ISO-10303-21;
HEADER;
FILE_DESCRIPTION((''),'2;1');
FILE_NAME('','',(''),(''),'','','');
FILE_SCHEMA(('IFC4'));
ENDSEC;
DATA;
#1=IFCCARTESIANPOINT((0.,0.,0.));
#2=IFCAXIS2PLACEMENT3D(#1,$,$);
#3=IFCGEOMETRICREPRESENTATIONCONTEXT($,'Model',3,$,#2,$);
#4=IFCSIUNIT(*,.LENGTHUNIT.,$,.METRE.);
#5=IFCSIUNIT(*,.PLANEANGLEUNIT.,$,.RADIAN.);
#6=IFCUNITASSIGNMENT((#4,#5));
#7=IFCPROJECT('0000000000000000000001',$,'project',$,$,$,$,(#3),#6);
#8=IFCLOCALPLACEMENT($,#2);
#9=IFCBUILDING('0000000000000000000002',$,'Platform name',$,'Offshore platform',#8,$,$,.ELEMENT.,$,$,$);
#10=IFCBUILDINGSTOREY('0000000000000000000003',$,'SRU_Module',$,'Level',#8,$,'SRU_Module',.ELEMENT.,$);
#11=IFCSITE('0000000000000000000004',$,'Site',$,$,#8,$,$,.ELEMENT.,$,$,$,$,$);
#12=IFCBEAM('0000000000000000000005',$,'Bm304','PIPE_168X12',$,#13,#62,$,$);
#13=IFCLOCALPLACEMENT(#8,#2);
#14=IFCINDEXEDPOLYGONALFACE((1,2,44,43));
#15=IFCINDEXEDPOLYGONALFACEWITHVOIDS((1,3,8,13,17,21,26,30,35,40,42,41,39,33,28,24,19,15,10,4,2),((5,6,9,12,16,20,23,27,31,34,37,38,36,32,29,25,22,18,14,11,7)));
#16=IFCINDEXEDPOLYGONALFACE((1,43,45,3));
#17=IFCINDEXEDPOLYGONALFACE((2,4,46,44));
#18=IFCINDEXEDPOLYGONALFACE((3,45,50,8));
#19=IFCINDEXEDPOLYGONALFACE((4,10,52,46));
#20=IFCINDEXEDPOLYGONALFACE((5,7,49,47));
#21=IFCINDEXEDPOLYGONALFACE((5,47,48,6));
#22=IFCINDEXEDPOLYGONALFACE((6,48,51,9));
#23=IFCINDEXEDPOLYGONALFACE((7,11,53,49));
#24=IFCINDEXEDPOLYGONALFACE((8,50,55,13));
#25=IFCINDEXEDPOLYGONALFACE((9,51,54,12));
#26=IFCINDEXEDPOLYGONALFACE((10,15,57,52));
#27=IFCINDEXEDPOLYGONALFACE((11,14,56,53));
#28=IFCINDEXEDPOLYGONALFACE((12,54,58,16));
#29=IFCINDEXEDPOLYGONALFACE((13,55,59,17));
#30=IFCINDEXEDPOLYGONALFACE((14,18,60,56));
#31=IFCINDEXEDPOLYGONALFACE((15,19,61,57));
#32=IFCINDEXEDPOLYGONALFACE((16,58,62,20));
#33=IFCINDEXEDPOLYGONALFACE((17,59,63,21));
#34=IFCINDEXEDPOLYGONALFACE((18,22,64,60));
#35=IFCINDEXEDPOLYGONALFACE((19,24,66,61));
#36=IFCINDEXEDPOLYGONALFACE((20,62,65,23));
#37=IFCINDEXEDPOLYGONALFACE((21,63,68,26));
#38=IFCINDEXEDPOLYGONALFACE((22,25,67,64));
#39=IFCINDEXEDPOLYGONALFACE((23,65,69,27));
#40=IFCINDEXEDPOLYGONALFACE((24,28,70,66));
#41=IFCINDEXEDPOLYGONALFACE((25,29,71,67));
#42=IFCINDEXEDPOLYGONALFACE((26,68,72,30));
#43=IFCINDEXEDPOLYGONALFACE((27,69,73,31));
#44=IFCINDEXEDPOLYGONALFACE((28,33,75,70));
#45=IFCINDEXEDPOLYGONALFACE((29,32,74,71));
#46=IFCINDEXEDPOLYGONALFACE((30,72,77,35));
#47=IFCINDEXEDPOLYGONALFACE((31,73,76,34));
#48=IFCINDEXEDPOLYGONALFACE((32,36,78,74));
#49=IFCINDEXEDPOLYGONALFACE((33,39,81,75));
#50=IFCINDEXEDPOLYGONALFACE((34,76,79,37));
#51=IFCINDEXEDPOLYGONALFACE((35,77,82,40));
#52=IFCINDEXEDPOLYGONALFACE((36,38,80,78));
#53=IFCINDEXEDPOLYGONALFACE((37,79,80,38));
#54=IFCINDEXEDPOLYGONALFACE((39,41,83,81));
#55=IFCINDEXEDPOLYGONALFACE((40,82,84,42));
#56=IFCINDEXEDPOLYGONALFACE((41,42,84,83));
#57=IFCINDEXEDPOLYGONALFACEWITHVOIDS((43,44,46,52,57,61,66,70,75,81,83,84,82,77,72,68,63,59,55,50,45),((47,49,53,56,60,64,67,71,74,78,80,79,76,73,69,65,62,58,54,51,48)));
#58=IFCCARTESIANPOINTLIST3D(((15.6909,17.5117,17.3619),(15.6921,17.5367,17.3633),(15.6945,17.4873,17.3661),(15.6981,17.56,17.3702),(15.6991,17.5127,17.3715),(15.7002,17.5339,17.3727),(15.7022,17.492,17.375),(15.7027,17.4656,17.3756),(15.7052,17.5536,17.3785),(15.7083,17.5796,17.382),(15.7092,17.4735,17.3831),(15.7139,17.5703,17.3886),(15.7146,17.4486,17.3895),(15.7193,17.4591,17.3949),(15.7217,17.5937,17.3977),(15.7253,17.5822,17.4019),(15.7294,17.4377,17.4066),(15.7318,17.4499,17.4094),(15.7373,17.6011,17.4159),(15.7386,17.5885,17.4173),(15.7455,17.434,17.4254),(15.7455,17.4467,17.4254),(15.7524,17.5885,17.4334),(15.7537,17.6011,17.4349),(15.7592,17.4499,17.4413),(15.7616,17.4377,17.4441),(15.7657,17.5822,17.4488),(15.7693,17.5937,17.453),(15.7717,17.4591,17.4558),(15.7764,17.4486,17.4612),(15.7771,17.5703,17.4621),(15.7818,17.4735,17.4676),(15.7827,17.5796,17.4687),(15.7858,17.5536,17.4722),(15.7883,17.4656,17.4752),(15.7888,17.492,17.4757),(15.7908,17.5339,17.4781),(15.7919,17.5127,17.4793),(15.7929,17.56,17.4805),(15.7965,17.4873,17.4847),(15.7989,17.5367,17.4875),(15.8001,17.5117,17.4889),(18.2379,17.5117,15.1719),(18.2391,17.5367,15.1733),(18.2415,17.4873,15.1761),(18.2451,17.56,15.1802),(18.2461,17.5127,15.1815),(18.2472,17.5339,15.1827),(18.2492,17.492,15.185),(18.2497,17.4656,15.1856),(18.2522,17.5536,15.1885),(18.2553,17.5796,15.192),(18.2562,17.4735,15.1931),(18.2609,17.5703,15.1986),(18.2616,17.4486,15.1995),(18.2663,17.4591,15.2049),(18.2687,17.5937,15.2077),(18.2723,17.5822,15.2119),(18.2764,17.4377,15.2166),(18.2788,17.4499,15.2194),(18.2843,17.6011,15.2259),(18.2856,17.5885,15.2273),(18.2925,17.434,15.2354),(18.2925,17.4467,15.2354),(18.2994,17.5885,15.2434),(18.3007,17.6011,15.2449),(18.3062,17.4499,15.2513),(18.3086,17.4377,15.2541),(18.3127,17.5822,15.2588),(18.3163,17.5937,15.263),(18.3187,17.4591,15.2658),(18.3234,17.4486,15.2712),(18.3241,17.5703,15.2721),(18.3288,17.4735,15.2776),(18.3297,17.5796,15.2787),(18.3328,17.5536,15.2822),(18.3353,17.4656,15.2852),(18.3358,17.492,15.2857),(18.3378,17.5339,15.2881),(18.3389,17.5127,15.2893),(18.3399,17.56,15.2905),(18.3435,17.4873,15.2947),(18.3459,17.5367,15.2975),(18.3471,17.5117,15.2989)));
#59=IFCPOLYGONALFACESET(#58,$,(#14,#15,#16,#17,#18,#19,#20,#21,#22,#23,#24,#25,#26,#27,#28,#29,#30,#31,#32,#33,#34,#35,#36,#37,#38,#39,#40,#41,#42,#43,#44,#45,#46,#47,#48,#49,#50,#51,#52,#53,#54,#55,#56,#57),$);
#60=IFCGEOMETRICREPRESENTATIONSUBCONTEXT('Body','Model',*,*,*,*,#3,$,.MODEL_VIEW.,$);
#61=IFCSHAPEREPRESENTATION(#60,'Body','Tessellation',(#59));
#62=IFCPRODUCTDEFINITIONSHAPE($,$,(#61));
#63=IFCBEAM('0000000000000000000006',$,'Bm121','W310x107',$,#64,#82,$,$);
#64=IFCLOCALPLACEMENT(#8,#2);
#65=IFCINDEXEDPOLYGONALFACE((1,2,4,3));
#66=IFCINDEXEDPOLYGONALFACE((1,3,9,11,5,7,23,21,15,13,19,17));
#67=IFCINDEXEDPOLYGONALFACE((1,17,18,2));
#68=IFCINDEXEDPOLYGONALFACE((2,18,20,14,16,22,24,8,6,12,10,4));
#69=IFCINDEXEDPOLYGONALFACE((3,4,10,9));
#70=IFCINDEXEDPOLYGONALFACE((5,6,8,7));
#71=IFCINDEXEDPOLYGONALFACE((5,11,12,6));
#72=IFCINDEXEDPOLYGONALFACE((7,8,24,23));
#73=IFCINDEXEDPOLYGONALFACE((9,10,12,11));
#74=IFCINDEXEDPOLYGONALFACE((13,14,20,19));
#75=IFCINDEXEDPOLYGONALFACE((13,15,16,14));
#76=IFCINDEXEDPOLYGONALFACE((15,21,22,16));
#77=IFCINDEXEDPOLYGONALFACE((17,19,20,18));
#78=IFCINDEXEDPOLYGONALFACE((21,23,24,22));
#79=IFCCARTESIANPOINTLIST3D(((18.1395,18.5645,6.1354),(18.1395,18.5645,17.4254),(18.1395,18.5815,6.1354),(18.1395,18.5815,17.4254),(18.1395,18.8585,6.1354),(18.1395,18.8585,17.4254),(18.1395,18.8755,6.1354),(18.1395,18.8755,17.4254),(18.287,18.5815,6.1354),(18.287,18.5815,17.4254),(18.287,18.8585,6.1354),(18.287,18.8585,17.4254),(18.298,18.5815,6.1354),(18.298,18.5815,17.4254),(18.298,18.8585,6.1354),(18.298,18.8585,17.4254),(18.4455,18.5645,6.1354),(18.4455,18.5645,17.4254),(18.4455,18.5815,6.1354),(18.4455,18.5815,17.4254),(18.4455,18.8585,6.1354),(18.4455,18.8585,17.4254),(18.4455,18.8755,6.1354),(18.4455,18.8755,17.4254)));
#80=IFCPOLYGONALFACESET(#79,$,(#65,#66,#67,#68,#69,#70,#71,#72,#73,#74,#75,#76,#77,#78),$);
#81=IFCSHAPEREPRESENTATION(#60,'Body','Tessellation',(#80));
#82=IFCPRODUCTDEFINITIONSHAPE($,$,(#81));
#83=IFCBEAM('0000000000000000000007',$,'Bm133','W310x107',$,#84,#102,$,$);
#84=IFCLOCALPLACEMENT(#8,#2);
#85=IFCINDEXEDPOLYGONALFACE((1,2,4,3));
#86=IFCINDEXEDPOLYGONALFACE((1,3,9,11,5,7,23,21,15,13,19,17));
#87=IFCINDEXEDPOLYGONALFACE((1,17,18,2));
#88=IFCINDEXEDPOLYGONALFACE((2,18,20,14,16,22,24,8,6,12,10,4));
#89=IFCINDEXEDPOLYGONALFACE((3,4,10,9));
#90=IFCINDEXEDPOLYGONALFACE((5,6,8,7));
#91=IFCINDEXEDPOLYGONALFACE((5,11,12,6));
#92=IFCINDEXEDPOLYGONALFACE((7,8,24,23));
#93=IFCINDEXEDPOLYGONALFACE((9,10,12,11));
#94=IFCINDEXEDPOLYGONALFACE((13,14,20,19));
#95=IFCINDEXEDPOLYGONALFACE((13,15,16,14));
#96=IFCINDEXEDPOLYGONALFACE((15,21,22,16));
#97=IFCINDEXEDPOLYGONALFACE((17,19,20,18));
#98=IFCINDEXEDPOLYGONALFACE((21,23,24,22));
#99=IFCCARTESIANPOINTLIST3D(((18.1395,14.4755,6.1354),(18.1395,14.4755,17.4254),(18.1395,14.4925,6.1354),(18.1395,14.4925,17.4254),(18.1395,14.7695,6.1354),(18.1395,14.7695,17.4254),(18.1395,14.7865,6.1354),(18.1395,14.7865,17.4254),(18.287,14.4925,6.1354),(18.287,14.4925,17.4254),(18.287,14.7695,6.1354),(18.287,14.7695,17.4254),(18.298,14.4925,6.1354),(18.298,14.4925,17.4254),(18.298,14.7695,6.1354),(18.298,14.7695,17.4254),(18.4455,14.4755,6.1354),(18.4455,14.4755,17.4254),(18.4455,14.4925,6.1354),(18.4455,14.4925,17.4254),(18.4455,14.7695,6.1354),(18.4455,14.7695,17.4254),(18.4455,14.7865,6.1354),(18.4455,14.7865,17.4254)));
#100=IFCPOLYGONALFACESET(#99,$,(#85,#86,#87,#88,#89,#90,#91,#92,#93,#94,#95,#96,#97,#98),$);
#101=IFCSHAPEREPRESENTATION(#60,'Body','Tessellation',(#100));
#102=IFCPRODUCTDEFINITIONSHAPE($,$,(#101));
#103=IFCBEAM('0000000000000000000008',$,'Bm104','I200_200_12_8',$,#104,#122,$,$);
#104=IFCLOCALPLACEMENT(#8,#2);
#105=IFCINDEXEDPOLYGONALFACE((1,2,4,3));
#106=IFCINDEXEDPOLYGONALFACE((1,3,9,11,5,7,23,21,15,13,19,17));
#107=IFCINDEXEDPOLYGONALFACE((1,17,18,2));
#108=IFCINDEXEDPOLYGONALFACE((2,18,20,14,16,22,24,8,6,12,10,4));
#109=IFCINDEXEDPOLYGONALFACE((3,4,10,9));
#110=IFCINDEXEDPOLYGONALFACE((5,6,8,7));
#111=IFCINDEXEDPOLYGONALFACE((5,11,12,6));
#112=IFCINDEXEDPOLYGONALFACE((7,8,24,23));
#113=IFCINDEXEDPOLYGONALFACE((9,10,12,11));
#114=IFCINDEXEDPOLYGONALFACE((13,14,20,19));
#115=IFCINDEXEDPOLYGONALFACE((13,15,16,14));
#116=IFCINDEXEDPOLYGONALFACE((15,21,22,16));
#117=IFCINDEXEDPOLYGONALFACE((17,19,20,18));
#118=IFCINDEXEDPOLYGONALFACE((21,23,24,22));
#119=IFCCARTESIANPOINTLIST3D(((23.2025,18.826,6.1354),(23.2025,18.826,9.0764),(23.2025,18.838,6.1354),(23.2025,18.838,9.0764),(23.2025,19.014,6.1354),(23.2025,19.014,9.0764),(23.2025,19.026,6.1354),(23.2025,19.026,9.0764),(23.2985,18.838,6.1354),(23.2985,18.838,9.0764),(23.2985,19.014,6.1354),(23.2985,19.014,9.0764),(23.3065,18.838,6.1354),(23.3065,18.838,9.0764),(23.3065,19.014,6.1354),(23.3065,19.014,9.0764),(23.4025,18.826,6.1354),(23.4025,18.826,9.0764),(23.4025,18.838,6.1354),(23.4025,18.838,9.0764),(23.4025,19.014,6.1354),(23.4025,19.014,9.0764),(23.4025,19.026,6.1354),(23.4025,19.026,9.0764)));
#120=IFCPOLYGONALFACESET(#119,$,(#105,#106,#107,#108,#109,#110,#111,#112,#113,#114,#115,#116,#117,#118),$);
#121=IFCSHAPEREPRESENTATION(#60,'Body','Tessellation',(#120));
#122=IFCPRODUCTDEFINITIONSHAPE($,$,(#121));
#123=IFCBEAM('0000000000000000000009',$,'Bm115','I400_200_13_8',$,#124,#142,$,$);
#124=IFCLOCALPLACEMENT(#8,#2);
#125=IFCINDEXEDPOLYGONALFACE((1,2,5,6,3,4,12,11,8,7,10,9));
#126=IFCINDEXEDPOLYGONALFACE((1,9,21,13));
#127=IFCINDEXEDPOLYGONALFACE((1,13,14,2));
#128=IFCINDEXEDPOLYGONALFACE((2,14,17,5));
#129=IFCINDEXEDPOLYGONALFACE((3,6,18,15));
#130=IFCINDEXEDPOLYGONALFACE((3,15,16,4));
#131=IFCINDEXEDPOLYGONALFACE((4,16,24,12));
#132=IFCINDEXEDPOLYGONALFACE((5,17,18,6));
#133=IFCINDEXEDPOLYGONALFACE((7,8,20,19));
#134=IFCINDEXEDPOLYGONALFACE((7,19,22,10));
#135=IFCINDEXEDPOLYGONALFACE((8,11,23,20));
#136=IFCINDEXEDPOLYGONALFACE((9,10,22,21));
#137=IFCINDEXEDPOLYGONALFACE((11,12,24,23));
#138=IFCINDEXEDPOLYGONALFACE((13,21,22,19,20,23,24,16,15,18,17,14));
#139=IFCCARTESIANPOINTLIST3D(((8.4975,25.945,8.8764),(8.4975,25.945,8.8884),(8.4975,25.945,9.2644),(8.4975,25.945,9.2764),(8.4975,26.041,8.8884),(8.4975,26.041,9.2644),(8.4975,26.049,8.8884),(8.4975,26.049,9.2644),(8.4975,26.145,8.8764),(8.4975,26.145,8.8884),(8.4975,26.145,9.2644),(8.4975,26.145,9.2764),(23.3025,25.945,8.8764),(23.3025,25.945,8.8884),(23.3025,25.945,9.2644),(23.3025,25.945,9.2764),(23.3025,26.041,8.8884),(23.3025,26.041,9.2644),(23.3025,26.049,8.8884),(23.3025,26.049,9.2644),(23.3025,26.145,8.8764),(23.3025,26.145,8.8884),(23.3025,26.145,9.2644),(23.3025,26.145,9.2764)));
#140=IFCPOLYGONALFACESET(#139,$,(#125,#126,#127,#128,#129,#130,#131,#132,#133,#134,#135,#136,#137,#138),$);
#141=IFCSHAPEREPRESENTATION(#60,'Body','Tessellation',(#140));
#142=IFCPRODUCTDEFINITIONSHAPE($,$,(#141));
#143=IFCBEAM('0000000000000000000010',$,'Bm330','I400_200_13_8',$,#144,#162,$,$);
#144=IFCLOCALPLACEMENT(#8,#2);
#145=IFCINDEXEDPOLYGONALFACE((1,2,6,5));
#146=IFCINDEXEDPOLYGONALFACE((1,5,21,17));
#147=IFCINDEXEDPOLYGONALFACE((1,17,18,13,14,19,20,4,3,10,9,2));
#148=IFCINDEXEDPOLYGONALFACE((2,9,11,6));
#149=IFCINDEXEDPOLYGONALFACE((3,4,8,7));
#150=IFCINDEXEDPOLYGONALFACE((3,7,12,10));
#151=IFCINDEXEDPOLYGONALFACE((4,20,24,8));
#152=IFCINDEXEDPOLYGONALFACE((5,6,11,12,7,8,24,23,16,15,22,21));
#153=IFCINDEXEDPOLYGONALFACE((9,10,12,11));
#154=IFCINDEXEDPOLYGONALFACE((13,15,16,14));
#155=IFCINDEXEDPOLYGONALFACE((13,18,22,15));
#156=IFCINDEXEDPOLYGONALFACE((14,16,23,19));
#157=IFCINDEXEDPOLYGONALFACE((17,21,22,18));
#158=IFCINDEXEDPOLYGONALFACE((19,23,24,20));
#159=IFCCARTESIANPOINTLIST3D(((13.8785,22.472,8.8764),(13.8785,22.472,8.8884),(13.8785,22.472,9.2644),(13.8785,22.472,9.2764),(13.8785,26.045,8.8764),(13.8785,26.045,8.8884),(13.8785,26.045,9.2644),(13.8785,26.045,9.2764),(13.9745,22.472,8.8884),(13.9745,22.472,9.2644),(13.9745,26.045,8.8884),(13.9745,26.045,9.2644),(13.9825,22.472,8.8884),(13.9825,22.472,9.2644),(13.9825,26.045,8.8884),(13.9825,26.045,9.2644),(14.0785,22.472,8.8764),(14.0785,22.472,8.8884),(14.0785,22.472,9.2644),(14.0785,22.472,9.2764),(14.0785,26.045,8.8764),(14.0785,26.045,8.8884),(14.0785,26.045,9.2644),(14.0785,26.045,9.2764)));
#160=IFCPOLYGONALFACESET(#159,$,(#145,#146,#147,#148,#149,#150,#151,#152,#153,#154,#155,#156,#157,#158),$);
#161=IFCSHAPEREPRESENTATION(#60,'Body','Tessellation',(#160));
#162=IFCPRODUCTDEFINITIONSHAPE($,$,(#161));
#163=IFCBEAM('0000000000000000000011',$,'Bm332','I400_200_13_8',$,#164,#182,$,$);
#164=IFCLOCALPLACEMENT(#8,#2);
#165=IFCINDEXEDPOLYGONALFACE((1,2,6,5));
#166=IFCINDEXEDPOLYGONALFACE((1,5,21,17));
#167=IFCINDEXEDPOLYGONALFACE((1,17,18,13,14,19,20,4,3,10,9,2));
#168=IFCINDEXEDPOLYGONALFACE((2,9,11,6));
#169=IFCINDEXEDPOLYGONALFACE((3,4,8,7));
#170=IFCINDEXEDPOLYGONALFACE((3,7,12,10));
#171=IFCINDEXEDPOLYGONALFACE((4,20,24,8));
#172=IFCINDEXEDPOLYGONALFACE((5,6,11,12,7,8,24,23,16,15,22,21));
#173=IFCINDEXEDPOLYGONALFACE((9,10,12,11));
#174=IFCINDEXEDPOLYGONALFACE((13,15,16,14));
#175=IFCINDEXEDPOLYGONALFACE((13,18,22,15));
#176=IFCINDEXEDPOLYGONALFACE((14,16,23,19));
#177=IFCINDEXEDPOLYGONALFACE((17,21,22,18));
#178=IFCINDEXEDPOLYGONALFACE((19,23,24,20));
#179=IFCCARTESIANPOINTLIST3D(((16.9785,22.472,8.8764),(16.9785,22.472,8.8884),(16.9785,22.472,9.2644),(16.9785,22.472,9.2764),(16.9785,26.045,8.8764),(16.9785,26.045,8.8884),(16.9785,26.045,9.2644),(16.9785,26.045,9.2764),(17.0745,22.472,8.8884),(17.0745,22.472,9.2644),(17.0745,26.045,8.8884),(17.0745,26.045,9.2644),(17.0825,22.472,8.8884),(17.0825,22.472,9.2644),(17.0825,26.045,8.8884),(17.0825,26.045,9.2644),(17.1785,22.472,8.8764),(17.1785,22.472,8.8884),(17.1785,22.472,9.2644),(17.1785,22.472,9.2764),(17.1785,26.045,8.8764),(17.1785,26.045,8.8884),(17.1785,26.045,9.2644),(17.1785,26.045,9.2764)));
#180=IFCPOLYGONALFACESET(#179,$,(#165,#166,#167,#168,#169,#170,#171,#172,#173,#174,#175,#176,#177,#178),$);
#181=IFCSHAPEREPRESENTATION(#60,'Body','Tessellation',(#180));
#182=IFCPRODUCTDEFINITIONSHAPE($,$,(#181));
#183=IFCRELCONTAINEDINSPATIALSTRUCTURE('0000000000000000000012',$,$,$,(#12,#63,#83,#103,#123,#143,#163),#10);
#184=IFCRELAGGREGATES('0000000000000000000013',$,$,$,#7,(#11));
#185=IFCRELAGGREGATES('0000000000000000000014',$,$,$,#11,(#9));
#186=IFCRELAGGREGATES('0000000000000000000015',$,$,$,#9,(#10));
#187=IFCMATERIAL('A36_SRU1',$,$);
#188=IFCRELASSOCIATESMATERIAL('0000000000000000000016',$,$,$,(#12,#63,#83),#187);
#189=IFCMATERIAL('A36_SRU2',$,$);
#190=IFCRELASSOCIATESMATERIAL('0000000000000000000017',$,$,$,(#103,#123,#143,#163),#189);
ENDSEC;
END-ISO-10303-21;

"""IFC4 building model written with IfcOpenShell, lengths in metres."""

from ifc_helpers import new_model, si_unit, frame, origin, origin_with_axes, origin_2d, place, context, subcontext, project, spatial, hollow_circle, i_section, extrude, source, transform, mapped, material, element, save


model = new_model("IFC4")

# Units and contexts
model_context = context("Model", 3, world=origin())
body_context = subcontext(model_context, "Body", "Model", "MODEL_VIEW")
ifc_project = project(units=[si_unit("LENGTHUNIT", "METRE"), si_unit("PLANEANGLEUNIT", "RADIAN")], contexts=[model_context])

# Site, building, storey
placement_1 = place(None, origin())
site = spatial("IfcSite", under=ifc_project, at=placement_1, Name="Site", CompositionType="ELEMENT")
building = spatial("IfcBuilding", under=site, at=placement_1, Name="Platform name", ObjectType="Offshore platform", CompositionType="ELEMENT")
storey = spatial("IfcBuildingStorey", under=building, at=placement_1, Name="SRU_Module", ObjectType="Level", LongName="SRU_Module", CompositionType="ELEMENT")

# Beams
ifc_material_1 = material(Name="A36_SRU1")
shared_shape_1 = source(origin(), body_context, "Body", "SweptSolid", [
    extrude(hollow_circle(Radius=0.084, WallThickness=0.0127, at=origin_2d()), frame((0.0, 0.0, 0.0), z_axis=(-0.758247, 0.0, 0.651967), x_axis=(0.0, -1.0, 0.0)), (0.0, 0.0, 1.0), 3.3591),
])
placement_2 = place(None, origin())
placement_3 = place(placement_2, origin())
placement_4 = place(placement_3, origin())
beam_1_placement = place(placement_4, frame((18.2925, 17.518, 15.2354)))
element("IfcBeam", 1, at=beam_1_placement, inside=storey, material=ifc_material_1, Name="Bm304", Description="PIPE_168X12", context=body_context, shape_type="MappedRepresentation", body=[
    mapped(shared_shape_1, transform((0.0, 0.0, 0.0), scale=1.0)),
])
shared_shape_2 = source(origin(), body_context, "Body", "SweptSolid", [
    extrude(i_section(OverallWidth=0.306, OverallDepth=0.311, WebThickness=0.0109, FlangeThickness=0.017, FilletRadius=0.0, at=origin_2d()), origin_with_axes(), (0.0, 0.0, 1.0), 11.29),
])
placement_5 = place(None, origin())
placement_6 = place(placement_5, origin())
placement_7 = place(placement_6, origin())
beam_2_placement = place(placement_7, frame((18.2925, 18.72, 6.1354)))
element("IfcBeam", 2, at=beam_2_placement, inside=storey, material=ifc_material_1, Name="Bm121", Description="W310x107", context=body_context, shape_type="MappedRepresentation", body=[
    mapped(shared_shape_2, transform((0.0, 0.0, 0.0), scale=1.0)),
])
shared_shape_3 = source(origin(), body_context, "Body", "SweptSolid", [
    extrude(i_section(OverallWidth=0.306, OverallDepth=0.311, WebThickness=0.0109, FlangeThickness=0.017, FilletRadius=0.0, at=origin_2d()), origin_with_axes(), (0.0, 0.0, 1.0), 11.29),
])
placement_8 = place(None, origin())
placement_9 = place(placement_8, origin())
placement_10 = place(placement_9, origin())
beam_3_placement = place(placement_10, frame((18.2925, 14.631, 6.1354)))
element("IfcBeam", 3, at=beam_3_placement, inside=storey, material=ifc_material_1, Name="Bm133", Description="W310x107", context=body_context, shape_type="MappedRepresentation", body=[
    mapped(shared_shape_3, transform((0.0, 0.0, 0.0), scale=1.0)),
])
ifc_material_2 = material(Name="A36_SRU2")
shared_shape_4 = source(origin(), body_context, "Body", "SweptSolid", [
    extrude(i_section(OverallWidth=0.2, OverallDepth=0.2, WebThickness=0.008, FlangeThickness=0.012, FilletRadius=0.0, at=origin_2d()), origin_with_axes(), (0.0, 0.0, 1.0), 2.941),
])
placement_11 = place(None, origin())
placement_12 = place(placement_11, origin())
placement_13 = place(placement_12, origin())
beam_4_placement = place(placement_13, frame((23.3025, 18.926, 6.1354)))
element("IfcBeam", 4, at=beam_4_placement, inside=storey, material=ifc_material_2, Name="Bm104", Description="I200_200_12_8", context=body_context, shape_type="MappedRepresentation", body=[
    mapped(shared_shape_4, transform((0.0, 0.0, 0.0), scale=1.0)),
])
shared_shape_5 = source(origin(), body_context, "Body", "SweptSolid", [
    extrude(i_section(OverallWidth=0.2, OverallDepth=0.4, WebThickness=0.008, FlangeThickness=0.012, FilletRadius=0.0, at=origin_2d()), frame((0.0, 0.0, 0.0), z_axis=(-1.0, 0.0, 0.0), x_axis=(0.0, -1.0, 0.0)), (0.0, 0.0, 1.0), 14.805),
])
placement_14 = place(None, origin())
placement_15 = place(placement_14, origin())
placement_16 = place(placement_15, origin())
beam_5_placement = place(placement_16, frame((23.3025, 26.045, 9.0764)))
element("IfcBeam", 5, at=beam_5_placement, inside=storey, material=ifc_material_2, Name="Bm115", Description="I400_200_13_8", context=body_context, shape_type="MappedRepresentation", body=[
    mapped(shared_shape_5, transform((0.0, 0.0, 0.0), scale=1.0)),
])
shared_shape_6 = source(origin(), body_context, "Body", "SweptSolid", [
    extrude(i_section(OverallWidth=0.2, OverallDepth=0.4, WebThickness=0.008, FlangeThickness=0.012, FilletRadius=0.0, at=origin_2d()), frame((0.0, 0.0, 0.0), z_axis=(0.0, 1.0, 0.0), x_axis=(-1.0, 0.0, 0.0)), (0.0, 0.0, 1.0), 3.573),
])
placement_17 = place(None, origin())
placement_18 = place(placement_17, origin())
placement_19 = place(placement_18, origin())
beam_6_placement = place(placement_19, frame((13.9785, 22.472, 9.0764)))
element("IfcBeam", 6, at=beam_6_placement, inside=storey, material=ifc_material_2, Name="Bm330", Description="I400_200_13_8", context=body_context, shape_type="MappedRepresentation", body=[
    mapped(shared_shape_6, transform((0.0, 0.0, 0.0), scale=1.0)),
])
shared_shape_7 = source(origin(), body_context, "Body", "SweptSolid", [
    extrude(i_section(OverallWidth=0.2, OverallDepth=0.4, WebThickness=0.008, FlangeThickness=0.012, FilletRadius=0.0, at=origin_2d()), frame((0.0, 0.0, 0.0), z_axis=(0.0, 1.0, 0.0), x_axis=(-1.0, 0.0, 0.0)), (0.0, 0.0, 1.0), 3.573),
])
placement_20 = place(None, origin())
placement_21 = place(placement_20, origin())
placement_22 = place(placement_21, origin())
beam_7_placement = place(placement_22, frame((17.0785, 22.472, 9.0764)))
element("IfcBeam", 7, at=beam_7_placement, inside=storey, material=ifc_material_2, Name="Bm332", Description="I400_200_13_8", context=body_context, shape_type="MappedRepresentation", body=[
    mapped(shared_shape_7, transform((0.0, 0.0, 0.0), scale=1.0)),
])

save(model, "model.ifc")
